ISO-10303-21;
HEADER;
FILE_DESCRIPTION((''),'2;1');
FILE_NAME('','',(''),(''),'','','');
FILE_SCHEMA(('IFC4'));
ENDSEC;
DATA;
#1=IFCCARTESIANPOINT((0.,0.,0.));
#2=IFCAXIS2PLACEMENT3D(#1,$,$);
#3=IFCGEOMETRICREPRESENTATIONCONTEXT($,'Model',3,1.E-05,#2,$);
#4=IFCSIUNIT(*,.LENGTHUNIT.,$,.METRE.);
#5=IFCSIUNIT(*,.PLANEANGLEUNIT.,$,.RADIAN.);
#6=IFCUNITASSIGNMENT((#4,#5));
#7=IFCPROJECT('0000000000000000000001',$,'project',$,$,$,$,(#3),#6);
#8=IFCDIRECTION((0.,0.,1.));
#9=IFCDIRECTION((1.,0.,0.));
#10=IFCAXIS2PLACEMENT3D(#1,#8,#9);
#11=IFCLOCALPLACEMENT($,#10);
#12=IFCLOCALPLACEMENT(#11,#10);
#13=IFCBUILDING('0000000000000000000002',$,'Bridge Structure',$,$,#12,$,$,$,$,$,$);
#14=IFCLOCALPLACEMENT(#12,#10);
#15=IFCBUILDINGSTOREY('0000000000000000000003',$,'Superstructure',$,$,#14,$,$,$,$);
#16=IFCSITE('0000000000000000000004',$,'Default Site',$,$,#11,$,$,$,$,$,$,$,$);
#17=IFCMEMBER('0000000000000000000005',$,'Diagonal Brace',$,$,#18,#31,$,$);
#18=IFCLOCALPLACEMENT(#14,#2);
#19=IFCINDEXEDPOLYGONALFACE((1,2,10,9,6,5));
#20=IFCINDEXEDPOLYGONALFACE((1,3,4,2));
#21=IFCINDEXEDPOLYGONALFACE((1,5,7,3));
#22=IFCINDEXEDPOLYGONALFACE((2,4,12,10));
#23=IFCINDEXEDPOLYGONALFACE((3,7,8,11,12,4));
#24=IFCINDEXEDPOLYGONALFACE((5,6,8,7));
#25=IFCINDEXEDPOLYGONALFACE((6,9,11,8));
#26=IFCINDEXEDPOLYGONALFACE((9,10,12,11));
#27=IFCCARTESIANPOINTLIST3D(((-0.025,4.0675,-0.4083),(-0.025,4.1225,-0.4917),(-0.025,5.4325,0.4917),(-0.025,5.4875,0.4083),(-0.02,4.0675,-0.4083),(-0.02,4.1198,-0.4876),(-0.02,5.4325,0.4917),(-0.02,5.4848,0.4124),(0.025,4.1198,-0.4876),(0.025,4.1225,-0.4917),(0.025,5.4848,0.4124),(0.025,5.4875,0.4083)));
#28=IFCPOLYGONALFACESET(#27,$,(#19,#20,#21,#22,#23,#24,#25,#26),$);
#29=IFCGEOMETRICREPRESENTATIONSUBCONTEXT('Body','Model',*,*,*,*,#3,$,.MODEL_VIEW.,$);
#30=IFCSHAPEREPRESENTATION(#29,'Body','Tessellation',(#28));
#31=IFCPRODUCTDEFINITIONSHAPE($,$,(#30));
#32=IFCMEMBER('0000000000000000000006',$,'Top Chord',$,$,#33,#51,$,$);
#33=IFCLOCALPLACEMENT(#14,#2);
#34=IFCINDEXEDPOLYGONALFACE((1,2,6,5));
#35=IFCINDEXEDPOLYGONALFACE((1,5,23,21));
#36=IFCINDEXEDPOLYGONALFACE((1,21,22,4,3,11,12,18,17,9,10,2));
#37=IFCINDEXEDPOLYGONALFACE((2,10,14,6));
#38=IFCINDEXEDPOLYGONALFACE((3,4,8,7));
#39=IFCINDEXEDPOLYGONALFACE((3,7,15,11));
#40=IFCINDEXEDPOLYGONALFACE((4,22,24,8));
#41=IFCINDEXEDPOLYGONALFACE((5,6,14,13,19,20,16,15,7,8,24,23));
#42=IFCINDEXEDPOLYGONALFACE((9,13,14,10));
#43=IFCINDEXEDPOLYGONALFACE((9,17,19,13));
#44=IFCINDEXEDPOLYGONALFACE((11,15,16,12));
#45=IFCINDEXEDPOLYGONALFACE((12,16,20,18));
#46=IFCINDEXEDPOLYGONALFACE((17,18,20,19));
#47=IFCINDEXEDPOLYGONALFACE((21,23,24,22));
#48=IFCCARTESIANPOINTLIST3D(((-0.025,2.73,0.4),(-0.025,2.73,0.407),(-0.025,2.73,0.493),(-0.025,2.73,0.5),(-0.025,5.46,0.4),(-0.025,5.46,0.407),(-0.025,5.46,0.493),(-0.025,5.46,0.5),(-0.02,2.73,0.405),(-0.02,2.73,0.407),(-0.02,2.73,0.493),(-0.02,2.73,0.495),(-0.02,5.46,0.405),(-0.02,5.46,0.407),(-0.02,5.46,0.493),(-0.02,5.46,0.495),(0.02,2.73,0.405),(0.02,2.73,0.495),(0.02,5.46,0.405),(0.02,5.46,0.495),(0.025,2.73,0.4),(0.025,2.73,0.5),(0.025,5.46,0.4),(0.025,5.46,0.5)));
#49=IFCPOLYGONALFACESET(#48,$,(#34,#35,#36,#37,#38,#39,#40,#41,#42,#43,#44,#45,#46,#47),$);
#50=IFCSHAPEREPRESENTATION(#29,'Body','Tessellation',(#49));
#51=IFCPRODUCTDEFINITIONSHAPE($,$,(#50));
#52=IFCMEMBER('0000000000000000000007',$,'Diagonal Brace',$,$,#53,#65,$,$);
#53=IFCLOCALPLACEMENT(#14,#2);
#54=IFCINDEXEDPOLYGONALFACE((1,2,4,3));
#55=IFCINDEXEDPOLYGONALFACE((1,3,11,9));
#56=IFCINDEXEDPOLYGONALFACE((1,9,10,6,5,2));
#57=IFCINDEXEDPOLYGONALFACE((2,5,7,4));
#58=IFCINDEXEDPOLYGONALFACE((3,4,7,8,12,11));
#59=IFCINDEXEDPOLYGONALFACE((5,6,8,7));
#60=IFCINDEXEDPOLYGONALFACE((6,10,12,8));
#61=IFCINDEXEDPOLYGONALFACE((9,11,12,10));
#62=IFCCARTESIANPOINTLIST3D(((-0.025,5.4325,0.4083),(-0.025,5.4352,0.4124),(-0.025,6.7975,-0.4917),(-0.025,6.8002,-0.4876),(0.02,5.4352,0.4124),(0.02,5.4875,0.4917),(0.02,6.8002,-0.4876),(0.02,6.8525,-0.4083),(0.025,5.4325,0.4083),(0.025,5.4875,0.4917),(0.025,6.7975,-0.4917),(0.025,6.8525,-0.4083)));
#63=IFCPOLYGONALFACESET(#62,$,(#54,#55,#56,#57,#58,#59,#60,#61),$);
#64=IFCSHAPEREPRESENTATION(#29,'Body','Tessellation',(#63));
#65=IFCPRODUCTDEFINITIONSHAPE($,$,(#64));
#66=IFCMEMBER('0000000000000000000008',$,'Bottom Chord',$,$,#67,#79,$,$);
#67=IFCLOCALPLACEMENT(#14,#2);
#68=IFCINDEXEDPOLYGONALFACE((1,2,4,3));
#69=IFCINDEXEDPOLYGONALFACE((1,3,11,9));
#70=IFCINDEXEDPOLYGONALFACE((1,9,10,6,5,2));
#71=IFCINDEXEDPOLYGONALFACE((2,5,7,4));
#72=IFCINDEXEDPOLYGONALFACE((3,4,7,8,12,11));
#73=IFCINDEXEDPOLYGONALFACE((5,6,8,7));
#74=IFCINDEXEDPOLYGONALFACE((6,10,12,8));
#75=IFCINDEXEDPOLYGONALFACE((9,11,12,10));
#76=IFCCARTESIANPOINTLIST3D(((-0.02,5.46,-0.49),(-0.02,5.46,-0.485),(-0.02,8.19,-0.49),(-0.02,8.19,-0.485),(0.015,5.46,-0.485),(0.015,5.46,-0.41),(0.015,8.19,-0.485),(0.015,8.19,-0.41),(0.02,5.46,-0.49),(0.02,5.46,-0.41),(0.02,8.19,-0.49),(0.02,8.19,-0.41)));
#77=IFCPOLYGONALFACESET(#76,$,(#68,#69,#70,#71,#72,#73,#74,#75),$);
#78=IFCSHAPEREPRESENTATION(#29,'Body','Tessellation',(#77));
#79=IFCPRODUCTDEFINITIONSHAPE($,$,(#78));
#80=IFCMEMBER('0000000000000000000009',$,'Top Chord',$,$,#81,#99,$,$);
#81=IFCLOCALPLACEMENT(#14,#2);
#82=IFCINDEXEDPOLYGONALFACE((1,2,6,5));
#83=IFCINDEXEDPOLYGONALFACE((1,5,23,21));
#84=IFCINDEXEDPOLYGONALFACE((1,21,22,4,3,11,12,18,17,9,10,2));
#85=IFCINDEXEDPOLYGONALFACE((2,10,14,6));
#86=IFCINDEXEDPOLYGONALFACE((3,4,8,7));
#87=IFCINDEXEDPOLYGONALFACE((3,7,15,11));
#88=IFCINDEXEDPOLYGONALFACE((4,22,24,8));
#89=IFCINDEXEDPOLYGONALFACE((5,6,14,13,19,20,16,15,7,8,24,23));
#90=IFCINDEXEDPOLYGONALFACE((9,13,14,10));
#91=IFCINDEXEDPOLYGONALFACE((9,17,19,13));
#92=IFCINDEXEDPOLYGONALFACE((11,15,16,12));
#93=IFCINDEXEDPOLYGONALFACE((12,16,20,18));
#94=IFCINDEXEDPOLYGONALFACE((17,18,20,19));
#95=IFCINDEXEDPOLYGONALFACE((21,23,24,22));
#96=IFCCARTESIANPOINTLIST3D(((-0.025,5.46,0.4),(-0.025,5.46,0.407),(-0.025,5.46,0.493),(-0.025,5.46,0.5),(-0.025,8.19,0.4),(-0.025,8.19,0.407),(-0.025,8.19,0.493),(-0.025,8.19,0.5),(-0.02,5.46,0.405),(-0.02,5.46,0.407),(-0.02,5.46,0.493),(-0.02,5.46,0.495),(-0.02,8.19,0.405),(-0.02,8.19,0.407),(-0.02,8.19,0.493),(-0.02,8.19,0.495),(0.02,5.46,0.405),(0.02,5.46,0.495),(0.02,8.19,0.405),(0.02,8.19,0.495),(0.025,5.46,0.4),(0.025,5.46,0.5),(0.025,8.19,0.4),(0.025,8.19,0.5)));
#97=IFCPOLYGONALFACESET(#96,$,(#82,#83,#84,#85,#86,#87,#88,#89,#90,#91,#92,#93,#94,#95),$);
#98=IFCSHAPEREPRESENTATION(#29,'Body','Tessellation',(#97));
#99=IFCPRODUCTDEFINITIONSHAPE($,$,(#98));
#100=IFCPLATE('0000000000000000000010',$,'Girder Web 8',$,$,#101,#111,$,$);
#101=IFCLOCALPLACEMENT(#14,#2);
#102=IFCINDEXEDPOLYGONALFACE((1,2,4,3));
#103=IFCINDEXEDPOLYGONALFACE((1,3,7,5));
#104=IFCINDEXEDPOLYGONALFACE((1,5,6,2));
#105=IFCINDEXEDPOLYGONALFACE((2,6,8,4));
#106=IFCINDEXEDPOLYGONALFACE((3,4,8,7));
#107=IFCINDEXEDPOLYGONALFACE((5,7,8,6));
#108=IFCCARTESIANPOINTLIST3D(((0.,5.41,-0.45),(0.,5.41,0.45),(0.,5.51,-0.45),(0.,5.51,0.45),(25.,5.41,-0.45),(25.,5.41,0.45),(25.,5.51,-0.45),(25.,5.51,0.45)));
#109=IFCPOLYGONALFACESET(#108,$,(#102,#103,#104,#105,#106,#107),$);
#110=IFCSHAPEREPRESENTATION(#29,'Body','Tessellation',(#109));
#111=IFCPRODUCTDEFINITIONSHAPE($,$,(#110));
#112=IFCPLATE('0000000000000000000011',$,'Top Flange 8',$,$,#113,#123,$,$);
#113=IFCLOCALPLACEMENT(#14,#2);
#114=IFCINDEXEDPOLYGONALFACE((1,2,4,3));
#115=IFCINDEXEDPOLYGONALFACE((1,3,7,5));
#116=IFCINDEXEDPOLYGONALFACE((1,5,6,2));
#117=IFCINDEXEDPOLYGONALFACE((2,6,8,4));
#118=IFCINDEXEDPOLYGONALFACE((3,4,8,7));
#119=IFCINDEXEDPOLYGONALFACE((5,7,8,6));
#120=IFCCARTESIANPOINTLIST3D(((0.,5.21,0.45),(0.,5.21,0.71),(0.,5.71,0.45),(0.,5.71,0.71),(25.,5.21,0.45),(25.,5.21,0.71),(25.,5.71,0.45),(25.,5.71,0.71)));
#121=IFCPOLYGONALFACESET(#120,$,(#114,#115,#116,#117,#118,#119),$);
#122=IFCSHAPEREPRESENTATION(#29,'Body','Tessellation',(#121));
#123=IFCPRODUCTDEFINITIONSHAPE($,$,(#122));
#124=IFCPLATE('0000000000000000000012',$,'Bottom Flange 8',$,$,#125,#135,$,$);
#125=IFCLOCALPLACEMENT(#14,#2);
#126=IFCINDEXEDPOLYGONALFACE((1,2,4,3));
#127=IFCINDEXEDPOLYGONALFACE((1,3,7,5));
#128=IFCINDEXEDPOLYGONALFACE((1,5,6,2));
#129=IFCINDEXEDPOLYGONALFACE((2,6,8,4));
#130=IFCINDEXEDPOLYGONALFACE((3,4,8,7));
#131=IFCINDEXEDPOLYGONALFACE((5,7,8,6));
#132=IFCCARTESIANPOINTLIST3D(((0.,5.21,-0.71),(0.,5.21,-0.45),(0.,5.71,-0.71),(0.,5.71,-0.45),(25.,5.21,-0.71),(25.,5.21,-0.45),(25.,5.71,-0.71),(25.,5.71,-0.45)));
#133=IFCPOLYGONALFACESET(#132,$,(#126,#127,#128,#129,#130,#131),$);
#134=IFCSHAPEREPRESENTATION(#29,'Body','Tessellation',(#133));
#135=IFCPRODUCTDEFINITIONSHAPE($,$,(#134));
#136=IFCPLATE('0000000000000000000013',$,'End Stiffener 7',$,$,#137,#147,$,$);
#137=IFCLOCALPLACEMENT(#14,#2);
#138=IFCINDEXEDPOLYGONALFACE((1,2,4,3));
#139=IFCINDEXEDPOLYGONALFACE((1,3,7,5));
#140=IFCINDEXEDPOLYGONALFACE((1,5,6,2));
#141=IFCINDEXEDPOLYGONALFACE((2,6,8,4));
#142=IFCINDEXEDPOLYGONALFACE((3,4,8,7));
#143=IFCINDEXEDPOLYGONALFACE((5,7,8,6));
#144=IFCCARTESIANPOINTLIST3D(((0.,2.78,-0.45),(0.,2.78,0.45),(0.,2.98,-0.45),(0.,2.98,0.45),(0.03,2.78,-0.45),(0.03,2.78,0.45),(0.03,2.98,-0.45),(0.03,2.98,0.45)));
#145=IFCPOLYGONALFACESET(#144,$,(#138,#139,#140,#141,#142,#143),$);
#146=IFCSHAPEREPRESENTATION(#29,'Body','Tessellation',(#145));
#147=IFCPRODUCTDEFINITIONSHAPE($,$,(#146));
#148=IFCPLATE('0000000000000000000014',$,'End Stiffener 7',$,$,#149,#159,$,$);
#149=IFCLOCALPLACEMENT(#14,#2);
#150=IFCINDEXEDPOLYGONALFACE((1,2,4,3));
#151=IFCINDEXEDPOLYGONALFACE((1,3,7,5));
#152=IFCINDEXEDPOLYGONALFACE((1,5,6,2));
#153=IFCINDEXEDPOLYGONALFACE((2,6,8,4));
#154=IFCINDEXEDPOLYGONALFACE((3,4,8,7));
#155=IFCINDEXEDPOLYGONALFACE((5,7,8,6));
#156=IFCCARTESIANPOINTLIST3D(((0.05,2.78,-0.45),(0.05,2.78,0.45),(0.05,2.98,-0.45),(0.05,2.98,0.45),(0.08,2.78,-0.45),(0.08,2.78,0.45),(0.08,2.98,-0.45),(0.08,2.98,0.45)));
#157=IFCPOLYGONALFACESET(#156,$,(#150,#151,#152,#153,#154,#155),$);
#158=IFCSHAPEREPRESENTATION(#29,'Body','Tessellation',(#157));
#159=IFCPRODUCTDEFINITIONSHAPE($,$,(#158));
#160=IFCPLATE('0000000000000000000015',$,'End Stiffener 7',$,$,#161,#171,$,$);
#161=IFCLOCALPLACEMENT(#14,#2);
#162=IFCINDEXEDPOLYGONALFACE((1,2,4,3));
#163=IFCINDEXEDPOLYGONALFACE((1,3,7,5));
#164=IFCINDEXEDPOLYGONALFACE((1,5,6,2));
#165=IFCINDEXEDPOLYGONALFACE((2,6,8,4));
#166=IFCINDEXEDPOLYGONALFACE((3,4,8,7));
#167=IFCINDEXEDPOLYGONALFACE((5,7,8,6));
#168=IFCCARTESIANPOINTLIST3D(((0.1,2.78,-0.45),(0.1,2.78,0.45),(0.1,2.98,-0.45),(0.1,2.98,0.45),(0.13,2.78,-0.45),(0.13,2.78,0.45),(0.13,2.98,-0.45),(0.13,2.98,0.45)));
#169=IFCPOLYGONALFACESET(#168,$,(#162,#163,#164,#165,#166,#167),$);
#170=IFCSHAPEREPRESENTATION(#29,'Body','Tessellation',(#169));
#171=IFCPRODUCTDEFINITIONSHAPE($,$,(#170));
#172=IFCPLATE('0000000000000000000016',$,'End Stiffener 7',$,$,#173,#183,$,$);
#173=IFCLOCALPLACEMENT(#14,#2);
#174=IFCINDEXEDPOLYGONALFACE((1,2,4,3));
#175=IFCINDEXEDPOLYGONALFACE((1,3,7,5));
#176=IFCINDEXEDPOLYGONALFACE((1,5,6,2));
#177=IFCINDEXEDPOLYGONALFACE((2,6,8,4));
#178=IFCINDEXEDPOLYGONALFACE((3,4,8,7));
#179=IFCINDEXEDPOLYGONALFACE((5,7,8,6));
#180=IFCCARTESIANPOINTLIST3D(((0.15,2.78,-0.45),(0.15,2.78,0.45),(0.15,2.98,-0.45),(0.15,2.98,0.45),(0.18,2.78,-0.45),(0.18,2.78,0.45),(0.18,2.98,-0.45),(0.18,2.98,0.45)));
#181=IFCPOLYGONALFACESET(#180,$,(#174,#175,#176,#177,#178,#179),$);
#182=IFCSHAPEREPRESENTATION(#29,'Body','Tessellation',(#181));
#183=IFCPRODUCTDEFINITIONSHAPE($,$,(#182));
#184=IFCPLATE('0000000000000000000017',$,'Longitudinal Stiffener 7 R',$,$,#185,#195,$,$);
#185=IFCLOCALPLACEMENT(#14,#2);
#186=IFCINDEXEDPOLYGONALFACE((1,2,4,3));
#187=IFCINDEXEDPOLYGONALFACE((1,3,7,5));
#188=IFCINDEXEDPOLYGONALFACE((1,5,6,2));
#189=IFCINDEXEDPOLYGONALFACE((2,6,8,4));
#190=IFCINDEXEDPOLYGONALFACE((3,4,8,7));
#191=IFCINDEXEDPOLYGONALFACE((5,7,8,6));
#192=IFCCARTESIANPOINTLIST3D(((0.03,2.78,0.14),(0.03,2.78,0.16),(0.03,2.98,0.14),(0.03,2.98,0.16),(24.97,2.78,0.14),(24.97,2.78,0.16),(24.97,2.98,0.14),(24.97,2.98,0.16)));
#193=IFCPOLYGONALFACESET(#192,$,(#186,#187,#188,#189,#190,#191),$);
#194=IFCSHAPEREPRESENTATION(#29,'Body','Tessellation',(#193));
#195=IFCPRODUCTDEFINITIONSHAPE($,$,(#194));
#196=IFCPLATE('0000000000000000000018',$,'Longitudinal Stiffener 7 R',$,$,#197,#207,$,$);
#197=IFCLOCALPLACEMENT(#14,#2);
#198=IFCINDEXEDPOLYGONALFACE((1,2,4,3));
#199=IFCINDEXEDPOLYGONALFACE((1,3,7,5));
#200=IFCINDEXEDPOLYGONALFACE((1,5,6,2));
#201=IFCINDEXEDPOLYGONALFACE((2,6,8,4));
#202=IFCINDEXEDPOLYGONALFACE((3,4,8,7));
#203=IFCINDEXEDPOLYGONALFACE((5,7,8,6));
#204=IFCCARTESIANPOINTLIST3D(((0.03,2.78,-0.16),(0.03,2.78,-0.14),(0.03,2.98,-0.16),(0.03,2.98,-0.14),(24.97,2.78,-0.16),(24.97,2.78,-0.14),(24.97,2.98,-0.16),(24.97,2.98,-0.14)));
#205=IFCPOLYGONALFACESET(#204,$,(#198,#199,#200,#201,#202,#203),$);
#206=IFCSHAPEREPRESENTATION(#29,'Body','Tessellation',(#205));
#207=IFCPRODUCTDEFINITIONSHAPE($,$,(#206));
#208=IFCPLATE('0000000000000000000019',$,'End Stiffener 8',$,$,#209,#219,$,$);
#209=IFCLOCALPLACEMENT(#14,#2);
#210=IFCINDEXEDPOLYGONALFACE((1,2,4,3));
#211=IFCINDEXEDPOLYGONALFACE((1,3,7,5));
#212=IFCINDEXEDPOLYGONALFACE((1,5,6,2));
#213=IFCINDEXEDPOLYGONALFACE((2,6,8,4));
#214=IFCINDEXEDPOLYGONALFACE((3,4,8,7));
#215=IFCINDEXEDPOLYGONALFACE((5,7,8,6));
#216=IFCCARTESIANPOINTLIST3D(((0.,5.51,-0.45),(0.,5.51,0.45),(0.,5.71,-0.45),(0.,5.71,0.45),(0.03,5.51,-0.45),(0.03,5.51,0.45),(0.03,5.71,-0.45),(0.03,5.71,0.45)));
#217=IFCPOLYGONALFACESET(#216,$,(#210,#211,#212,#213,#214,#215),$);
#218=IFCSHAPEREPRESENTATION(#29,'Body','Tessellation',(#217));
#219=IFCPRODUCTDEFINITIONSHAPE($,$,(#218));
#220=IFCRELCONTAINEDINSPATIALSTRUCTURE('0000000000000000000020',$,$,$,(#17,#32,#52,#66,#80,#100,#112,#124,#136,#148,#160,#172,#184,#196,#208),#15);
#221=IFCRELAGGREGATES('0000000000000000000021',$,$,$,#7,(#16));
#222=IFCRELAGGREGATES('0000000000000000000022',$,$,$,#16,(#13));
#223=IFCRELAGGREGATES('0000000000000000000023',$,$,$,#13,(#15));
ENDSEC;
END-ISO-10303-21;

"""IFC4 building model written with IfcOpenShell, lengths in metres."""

from ifc_helpers import new_model, si_unit, frame, origin, origin_with_axes, origin_2d_with_axis, place, context, subcontext, project, spatial, rectangle, l_section, c_section, extrude, element, save


model = new_model("IFC4")

# Units and contexts
model_context = context("Model", 3, precision=1e-05, world=origin())
body_context = subcontext(model_context, "Body", "Model", "MODEL_VIEW")
ifc_project = project(units=[si_unit("LENGTHUNIT", "METRE"), si_unit("PLANEANGLEUNIT", "RADIAN")], contexts=[model_context])

# Site, building, storey
site_placement = place(None, origin_with_axes())
site = spatial("IfcSite", under=ifc_project, at=site_placement, Name="Default Site")
building_placement = place(site_placement, origin_with_axes())
building = spatial("IfcBuilding", under=site, at=building_placement, Name="Bridge Structure")
storey_placement = place(building_placement, origin_with_axes())
storey = spatial("IfcBuildingStorey", under=building, at=storey_placement, Name="Superstructure")

# Members
member_1_placement = place(storey_placement, frame((0.0, 5.46, 0.45), z_axis=(0.0, -0.834862, -0.550459), x_axis=(1.0, 0.0, 0.0)))
element("IfcMember", 1, at=member_1_placement, inside=storey, Name="Diagonal Brace", context=body_context, shape_type="SweptSolid", body=[
    extrude(l_section(Depth=0.1, Width=0.05, Thickness=0.005, at=origin_2d_with_axis()), origin_with_axes(), (0.0, 0.0, 1.0), 1.635),
])
member_2_placement = place(storey_placement, frame((0.0, 2.73, 0.45), z_axis=(0.0, 1.0, 0.0), x_axis=(-1.0, 0.0, 0.0)))
element("IfcMember", 2, at=member_2_placement, inside=storey, Name="Top Chord", context=body_context, shape_type="SweptSolid", body=[
    extrude(c_section(Depth=0.1, Width=0.05, WallThickness=0.005, Girth=0.007, at=origin_2d_with_axis()), origin_with_axes(), (0.0, 0.0, 1.0), 2.73),
])
member_3_placement = place(storey_placement, frame((0.0, 5.46, 0.45), z_axis=(0.0, 0.834862, -0.550459), x_axis=(-1.0, 0.0, 0.0)))
element("IfcMember", 3, at=member_3_placement, inside=storey, Name="Diagonal Brace", context=body_context, shape_type="SweptSolid", body=[
    extrude(l_section(Depth=0.1, Width=0.05, Thickness=0.005, at=origin_2d_with_axis()), origin_with_axes(), (0.0, 0.0, 1.0), 1.635),
])
member_4_placement = place(storey_placement, frame((0.0, 5.46, -0.45), z_axis=(0.0, 1.0, 0.0), x_axis=(-1.0, 0.0, 0.0)))
element("IfcMember", 4, at=member_4_placement, inside=storey, Name="Bottom Chord", context=body_context, shape_type="SweptSolid", body=[
    extrude(l_section(Depth=0.08, Width=0.04, Thickness=0.005, at=origin_2d_with_axis()), origin_with_axes(), (0.0, 0.0, 1.0), 2.73),
])
member_5_placement = place(storey_placement, frame((0.0, 5.46, 0.45), z_axis=(0.0, 1.0, 0.0), x_axis=(-1.0, 0.0, 0.0)))
element("IfcMember", 5, at=member_5_placement, inside=storey, Name="Top Chord", context=body_context, shape_type="SweptSolid", body=[
    extrude(c_section(Depth=0.1, Width=0.05, WallThickness=0.005, Girth=0.007, at=origin_2d_with_axis()), origin_with_axes(), (0.0, 0.0, 1.0), 2.73),
])

# Plates
plate_placement = place(storey_placement, frame((0.0, 5.46, 0.0), z_axis=(1.0, 0.0, 0.0), x_axis=(0.0, 1.0, 0.0)))
element("IfcPlate", 6, at=plate_placement, inside=storey, Name="Girder Web 8", context=body_context, shape_type="SweptSolid", body=[
    extrude(rectangle(XDim=0.1, YDim=0.9, at=origin_2d_with_axis()), origin_with_axes(), (0.0, 0.0, 1.0), 25.0),
])
for number, where, z_axis, x_axis, name in (
    (7, (0.0, 5.46, 0.58), (1.0, 0.0, 0.0), (0.0, 1.0, 0.0), "Top Flange 8"),
    (8, (0.0, 5.46, -0.58), (1.0, 0.0, 0.0), (0.0, 1.0, 0.0), "Bottom Flange 8"),
):
    element("IfcPlate", number, at=place(storey_placement, frame(where, z_axis=z_axis, x_axis=x_axis)), inside=storey, Name=name, context=body_context, shape_type="SweptSolid", body=[
        extrude(rectangle(XDim=0.5, YDim=0.26, at=origin_2d_with_axis()), origin_with_axes(), (0.0, 0.0, 1.0), 25.0),
    ])
for number, where, z_axis, x_axis, name in (
    (9, (0.015, 2.88, -0.45), (0.0, 0.0, 1.0), (1.0, 0.0, 0.0), "End Stiffener 7"),
    (10, (0.065, 2.88, -0.45), (0.0, 0.0, 1.0), (1.0, 0.0, 0.0), "End Stiffener 7"),
    (11, (0.115, 2.88, -0.45), (0.0, 0.0, 1.0), (1.0, 0.0, 0.0), "End Stiffener 7"),
    (12, (0.165, 2.88, -0.45), (0.0, 0.0, 1.0), (1.0, 0.0, 0.0), "End Stiffener 7"),
):
    element("IfcPlate", number, at=place(storey_placement, frame(where, z_axis=z_axis, x_axis=x_axis)), inside=storey, Name=name, context=body_context, shape_type="SweptSolid", body=[
        extrude(rectangle(XDim=0.03, YDim=0.2, at=origin_2d_with_axis()), origin_with_axes(), (0.0, 0.0, 1.0), 0.9),
    ])
for number, where, z_axis, x_axis, name in (
    (13, (0.03, 2.88, 0.15), (1.0, 0.0, 0.0), (0.0, 1.0, 0.0), "Longitudinal Stiffener 7 R"),
    (14, (0.03, 2.88, -0.15), (1.0, 0.0, 0.0), (0.0, 1.0, 0.0), "Longitudinal Stiffener 7 R"),
):
    element("IfcPlate", number, at=place(storey_placement, frame(where, z_axis=z_axis, x_axis=x_axis)), inside=storey, Name=name, context=body_context, shape_type="SweptSolid", body=[
        extrude(rectangle(XDim=0.2, YDim=0.02, at=origin_2d_with_axis()), origin_with_axes(), (0.0, 0.0, 1.0), 24.94),
    ])
for number, where, z_axis, x_axis, name in (
    (15, (0.015, 5.61, -0.45), (0.0, 0.0, 1.0), (1.0, 0.0, 0.0), "End Stiffener 8"),
):
    element("IfcPlate", number, at=place(storey_placement, frame(where, z_axis=z_axis, x_axis=x_axis)), inside=storey, Name=name, context=body_context, shape_type="SweptSolid", body=[
        extrude(rectangle(XDim=0.03, YDim=0.2, at=origin_2d_with_axis()), origin_with_axes(), (0.0, 0.0, 1.0), 0.9),
    ])

save(model, "model.ifc")
